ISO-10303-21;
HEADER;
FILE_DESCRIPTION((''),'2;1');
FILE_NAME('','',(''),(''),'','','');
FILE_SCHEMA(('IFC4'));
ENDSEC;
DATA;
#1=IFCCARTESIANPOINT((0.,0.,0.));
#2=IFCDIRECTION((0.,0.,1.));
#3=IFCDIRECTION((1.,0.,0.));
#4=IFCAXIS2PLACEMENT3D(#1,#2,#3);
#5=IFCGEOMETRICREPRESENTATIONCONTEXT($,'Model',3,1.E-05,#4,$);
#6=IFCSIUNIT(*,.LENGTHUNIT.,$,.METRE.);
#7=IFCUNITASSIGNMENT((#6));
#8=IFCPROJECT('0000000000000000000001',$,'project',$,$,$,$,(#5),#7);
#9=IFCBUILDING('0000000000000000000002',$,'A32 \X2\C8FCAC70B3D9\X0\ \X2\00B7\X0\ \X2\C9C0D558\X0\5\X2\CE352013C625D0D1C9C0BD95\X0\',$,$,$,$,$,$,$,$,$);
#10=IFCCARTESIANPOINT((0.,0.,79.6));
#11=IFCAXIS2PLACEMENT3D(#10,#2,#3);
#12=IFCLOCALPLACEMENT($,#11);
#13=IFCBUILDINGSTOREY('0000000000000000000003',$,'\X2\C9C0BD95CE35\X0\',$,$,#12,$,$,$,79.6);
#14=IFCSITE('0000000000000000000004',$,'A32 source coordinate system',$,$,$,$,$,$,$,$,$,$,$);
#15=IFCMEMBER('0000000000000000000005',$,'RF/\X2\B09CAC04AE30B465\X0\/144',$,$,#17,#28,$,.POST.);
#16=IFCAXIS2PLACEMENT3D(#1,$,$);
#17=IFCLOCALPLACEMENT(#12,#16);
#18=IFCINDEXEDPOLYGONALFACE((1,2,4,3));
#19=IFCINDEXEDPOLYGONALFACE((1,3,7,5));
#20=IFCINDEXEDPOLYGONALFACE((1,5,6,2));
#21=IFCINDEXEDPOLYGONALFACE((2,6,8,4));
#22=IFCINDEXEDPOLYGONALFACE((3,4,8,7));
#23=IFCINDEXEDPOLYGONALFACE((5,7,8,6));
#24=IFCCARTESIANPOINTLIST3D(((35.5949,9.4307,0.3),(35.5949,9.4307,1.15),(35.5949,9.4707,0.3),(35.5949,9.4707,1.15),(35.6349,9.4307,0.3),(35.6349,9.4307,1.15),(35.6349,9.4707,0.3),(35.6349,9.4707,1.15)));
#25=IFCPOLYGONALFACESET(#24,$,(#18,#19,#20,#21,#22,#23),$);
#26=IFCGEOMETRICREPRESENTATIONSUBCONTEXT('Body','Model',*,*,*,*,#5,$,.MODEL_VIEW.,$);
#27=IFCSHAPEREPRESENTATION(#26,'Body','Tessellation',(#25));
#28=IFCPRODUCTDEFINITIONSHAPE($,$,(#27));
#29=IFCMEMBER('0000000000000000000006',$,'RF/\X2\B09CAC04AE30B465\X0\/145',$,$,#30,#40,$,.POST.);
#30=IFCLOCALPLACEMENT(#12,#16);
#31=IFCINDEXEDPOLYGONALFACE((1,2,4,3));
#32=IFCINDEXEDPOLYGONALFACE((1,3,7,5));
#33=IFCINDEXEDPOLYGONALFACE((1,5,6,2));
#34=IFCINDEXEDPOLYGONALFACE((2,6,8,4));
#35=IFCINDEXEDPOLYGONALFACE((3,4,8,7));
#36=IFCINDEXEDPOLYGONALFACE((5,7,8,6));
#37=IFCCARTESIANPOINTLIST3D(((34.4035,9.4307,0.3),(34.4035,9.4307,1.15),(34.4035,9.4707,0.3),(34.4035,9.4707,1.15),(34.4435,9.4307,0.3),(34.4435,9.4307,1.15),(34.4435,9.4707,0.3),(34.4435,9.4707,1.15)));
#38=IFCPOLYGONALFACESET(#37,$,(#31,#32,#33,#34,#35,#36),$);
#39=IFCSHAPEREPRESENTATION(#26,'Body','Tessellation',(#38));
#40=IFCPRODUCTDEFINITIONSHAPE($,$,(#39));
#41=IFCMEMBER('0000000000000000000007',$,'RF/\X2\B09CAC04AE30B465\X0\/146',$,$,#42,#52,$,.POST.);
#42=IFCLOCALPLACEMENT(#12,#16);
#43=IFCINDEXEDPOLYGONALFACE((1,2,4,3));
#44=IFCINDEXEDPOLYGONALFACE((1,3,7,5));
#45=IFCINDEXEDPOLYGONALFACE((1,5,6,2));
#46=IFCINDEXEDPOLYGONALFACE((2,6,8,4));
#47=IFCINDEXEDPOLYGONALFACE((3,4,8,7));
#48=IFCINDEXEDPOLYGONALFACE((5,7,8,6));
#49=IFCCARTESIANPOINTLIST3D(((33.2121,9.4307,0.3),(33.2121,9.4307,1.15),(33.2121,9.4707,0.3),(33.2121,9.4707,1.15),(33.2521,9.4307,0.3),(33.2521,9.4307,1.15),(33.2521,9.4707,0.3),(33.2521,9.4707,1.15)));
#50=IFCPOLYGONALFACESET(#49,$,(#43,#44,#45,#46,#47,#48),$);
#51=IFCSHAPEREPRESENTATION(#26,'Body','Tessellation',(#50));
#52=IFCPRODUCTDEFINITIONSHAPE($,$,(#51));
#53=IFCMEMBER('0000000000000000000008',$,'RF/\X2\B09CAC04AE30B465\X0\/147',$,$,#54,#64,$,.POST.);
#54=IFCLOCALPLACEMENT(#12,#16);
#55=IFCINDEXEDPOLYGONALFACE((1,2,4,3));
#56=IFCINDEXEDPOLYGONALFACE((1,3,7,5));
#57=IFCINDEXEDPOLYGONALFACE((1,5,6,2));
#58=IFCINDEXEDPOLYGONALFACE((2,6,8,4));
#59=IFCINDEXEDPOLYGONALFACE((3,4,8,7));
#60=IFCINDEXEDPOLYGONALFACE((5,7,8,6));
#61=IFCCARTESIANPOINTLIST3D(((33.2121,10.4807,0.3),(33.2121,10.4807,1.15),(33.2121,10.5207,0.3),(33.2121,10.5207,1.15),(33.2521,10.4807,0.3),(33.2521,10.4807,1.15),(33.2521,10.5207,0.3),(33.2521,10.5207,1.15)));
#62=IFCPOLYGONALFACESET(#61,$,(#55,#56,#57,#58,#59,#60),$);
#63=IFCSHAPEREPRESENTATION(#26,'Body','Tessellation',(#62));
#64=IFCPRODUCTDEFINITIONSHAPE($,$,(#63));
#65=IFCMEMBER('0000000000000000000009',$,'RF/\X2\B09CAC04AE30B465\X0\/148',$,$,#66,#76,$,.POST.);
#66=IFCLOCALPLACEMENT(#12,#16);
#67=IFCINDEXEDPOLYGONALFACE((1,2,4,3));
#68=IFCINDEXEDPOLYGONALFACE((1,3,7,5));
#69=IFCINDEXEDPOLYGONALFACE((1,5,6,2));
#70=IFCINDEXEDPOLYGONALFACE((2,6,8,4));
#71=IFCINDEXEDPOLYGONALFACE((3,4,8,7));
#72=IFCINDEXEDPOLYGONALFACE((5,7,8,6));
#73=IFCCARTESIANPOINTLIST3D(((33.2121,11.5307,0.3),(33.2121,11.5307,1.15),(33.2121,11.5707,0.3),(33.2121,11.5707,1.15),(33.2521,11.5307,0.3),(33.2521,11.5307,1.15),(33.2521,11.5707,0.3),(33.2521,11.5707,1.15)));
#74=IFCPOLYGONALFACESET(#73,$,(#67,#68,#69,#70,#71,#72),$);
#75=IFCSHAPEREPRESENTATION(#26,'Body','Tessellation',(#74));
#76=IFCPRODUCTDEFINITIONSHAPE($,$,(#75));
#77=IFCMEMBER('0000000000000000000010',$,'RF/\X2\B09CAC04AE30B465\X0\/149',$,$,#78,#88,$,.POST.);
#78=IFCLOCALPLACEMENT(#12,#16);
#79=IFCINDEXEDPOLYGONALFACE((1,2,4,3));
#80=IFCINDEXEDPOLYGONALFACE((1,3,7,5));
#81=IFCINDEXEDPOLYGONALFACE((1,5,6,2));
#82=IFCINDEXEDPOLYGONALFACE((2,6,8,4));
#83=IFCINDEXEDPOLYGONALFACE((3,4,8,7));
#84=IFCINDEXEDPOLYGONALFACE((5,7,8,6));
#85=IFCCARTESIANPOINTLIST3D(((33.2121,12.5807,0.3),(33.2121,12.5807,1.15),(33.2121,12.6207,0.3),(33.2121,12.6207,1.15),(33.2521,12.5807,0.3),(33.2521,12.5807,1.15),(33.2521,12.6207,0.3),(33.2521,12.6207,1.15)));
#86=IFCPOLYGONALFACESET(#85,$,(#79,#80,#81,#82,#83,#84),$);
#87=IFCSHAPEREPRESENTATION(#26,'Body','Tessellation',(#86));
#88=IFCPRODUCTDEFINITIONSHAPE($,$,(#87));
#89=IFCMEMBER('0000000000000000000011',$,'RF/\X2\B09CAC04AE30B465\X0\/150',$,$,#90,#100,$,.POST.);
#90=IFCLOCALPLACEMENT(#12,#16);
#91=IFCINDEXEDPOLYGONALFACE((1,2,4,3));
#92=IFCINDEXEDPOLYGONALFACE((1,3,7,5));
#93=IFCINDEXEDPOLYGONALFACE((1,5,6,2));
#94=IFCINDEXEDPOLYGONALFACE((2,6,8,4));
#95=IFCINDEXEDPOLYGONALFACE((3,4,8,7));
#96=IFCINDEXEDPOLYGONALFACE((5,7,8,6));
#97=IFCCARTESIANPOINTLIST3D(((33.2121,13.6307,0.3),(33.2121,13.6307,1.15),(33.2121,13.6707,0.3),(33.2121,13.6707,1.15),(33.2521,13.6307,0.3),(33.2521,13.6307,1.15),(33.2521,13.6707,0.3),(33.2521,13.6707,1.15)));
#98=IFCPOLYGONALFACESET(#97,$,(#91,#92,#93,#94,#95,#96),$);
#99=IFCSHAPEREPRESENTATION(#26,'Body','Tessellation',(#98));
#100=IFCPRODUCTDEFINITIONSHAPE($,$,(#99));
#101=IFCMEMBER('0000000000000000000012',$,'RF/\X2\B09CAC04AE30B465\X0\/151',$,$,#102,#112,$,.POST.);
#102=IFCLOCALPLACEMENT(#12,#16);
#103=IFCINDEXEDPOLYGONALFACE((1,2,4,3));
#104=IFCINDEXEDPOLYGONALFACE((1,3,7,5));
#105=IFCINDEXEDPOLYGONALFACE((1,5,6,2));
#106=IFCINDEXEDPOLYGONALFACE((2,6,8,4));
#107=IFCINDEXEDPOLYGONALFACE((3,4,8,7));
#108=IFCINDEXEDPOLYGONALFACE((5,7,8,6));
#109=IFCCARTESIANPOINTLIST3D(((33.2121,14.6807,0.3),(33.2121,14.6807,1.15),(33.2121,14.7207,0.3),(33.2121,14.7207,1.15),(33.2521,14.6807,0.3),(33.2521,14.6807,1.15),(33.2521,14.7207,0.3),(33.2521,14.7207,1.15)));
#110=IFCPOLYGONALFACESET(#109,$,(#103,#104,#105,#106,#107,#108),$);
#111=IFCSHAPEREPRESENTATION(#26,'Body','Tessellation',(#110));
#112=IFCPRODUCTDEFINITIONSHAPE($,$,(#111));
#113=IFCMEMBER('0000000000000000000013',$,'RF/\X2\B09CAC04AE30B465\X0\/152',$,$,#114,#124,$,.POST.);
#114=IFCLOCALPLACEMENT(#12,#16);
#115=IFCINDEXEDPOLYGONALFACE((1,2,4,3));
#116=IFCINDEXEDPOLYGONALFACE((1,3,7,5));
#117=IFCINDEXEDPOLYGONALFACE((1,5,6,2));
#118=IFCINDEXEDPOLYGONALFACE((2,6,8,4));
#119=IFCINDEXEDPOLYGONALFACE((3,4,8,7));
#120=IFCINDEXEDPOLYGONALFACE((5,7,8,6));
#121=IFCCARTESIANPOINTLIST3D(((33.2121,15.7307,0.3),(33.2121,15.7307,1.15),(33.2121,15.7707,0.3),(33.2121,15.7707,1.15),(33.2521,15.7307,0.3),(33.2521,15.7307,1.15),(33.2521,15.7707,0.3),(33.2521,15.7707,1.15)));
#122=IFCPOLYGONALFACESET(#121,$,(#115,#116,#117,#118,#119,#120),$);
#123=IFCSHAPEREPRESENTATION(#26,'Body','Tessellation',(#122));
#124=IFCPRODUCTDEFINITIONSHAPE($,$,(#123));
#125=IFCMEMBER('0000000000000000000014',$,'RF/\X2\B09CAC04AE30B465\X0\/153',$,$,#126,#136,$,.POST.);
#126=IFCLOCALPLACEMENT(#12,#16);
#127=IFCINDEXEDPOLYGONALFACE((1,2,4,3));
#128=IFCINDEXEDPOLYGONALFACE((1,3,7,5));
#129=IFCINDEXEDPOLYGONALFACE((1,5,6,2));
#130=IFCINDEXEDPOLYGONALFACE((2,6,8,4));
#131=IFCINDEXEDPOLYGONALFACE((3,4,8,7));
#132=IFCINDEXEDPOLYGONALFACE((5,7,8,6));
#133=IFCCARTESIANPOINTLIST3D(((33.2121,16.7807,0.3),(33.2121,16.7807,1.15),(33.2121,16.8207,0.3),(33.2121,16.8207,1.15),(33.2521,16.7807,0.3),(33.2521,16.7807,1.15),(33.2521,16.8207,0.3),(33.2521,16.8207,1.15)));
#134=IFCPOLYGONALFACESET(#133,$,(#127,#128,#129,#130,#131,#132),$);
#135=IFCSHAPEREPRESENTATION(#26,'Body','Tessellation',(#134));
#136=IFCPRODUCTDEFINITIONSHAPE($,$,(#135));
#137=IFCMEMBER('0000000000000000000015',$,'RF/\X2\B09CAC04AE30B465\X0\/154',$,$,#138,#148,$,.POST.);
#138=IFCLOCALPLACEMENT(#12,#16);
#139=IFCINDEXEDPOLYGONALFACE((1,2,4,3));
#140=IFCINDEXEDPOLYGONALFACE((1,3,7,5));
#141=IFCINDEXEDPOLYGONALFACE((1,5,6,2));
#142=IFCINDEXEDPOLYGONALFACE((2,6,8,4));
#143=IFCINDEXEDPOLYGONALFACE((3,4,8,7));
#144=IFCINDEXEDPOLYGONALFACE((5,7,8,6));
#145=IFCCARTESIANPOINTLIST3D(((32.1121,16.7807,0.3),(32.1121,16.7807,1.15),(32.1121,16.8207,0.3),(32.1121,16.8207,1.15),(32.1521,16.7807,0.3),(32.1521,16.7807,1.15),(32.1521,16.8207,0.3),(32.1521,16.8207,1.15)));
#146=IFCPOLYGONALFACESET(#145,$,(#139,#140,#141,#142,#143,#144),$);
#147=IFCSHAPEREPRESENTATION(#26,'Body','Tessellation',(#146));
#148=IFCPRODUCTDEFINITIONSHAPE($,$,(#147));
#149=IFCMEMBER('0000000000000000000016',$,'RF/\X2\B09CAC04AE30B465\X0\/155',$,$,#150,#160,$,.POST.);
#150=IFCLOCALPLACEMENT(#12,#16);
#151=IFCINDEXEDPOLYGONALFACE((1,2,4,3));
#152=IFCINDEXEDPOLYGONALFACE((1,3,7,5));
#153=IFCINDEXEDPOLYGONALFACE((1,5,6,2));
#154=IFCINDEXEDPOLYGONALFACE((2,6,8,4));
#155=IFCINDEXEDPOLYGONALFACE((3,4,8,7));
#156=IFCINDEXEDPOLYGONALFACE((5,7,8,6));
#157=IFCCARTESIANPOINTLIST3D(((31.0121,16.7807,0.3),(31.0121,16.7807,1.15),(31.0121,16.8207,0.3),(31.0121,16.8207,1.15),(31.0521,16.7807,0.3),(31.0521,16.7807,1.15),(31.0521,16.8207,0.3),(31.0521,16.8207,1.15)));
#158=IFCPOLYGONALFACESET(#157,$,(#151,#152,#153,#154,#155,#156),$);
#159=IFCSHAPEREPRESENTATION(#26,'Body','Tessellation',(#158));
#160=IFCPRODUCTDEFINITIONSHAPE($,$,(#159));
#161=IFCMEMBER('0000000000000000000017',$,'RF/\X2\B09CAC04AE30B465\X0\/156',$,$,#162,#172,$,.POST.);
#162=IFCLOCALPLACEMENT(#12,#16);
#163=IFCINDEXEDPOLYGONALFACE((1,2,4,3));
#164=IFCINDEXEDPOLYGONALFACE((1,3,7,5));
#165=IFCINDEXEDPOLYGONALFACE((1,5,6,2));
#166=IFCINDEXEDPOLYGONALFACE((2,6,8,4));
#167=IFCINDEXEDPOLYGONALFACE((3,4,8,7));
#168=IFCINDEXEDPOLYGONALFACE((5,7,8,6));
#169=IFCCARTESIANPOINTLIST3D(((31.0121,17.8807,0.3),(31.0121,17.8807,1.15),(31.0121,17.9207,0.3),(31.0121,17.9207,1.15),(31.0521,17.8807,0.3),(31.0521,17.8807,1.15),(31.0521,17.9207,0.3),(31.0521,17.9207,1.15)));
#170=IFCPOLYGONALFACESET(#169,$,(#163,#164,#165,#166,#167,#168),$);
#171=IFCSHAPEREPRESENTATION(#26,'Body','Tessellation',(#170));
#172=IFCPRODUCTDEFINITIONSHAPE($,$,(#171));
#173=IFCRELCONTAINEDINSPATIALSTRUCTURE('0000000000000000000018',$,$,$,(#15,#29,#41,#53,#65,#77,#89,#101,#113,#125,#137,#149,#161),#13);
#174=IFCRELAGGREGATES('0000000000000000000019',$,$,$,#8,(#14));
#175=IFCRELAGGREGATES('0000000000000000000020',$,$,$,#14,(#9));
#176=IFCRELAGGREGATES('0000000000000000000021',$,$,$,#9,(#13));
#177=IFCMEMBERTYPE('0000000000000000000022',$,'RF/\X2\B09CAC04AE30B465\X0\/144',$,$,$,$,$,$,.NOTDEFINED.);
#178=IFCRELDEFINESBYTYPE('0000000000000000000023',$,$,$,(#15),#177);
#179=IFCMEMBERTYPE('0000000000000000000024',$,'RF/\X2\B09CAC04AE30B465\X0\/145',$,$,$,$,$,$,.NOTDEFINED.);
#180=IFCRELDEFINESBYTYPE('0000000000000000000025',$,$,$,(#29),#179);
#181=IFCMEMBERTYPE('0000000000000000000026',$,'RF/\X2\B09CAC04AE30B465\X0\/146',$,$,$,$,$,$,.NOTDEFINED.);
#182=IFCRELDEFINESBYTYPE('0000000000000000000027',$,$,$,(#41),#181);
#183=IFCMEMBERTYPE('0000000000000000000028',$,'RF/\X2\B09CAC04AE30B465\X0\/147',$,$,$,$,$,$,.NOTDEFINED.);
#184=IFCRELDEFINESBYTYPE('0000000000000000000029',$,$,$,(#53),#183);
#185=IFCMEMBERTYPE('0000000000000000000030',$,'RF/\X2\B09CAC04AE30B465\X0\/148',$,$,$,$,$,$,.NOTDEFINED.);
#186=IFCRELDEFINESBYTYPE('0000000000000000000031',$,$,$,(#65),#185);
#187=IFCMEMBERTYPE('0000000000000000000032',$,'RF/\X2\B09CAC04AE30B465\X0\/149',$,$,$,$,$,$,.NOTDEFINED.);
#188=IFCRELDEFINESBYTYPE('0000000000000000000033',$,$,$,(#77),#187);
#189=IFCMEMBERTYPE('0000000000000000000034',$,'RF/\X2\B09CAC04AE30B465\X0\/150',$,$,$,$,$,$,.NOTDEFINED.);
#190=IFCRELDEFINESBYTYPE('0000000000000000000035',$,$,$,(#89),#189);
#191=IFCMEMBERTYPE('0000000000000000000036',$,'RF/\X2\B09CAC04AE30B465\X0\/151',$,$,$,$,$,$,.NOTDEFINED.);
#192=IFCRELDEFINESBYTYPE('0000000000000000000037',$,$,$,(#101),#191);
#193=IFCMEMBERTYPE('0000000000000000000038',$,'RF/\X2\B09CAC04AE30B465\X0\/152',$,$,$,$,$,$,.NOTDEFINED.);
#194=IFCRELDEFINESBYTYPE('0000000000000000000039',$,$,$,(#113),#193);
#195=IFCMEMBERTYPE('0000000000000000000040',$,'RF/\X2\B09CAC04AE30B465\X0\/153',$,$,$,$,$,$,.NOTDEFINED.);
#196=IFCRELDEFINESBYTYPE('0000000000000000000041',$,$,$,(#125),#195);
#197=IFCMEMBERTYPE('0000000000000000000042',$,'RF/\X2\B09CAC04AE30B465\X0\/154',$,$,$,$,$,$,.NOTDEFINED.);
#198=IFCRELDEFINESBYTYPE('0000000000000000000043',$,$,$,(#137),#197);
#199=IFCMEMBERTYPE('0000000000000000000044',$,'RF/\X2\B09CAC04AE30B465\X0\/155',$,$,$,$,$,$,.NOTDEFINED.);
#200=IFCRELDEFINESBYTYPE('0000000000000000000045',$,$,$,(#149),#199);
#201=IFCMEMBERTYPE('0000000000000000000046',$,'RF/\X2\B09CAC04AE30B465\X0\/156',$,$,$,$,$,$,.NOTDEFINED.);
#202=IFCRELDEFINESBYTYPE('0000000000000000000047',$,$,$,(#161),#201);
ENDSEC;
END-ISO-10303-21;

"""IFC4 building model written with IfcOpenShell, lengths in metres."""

from ifc_helpers import new_model, si_unit, frame, origin, origin_with_axes, place, context, subcontext, project, spatial, polyline, outline, extrude, source, transform, mapped, type_object, type_shapes, element, save


model = new_model("IFC4")

# Units and contexts
model_context = context("Model", 3, precision=1e-05, world=origin_with_axes())
body_context = subcontext(model_context, "Body", "Model", "MODEL_VIEW")
ifc_project = project(units=[si_unit("LENGTHUNIT", "METRE")], contexts=[model_context])

# Site, building, storey
site = spatial("IfcSite", under=ifc_project, Name="A32 source coordinate system")
building = spatial("IfcBuilding", under=site, Name="A32 주거동 · 지하5층–옥탑지붕")
storey_placement = place(None, frame((0.0, 0.0, 79.6), z_axis=(0.0, 0.0, 1.0), x_axis=(1.0, 0.0, 0.0)))
storey = spatial("IfcBuildingStorey", under=building, at=storey_placement, Name="지붕층", Elevation=79.6)

# Members
member_type_1 = type_object("IfcMemberType", Name="RF/난간기둥/144", PredefinedType="NOTDEFINED")
shared_shape_1 = source(origin(), body_context, "Body", "SweptSolid", [
    extrude(outline(polyline([(35.6349, 9.4307), (35.5949, 9.4307), (35.5949, 9.4707), (35.6349, 9.4707), (35.6349, 9.4307)])), frame((0.0, 0.0, 0.3)), (0.0, 0.0, 1.0), 0.85),
])
type_shapes(member_type_1, [shared_shape_1])
member_1_placement = place(storey_placement, origin_with_axes())
element("IfcMember", 1, at=member_1_placement, inside=storey, type_object=member_type_1, Name="RF/난간기둥/144", PredefinedType="POST", context=body_context, shape_type="MappedRepresentation", body=[
    mapped(shared_shape_1, transform((0.0, 0.0, 0.0), scale=1.0)),
])
member_type_2 = type_object("IfcMemberType", Name="RF/난간기둥/145", PredefinedType="NOTDEFINED")
shared_shape_2 = source(origin(), body_context, "Body", "SweptSolid", [
    extrude(outline(polyline([(34.4435, 9.4307), (34.4035, 9.4307), (34.4035, 9.4707), (34.4435, 9.4707), (34.4435, 9.4307)])), frame((0.0, 0.0, 0.3)), (0.0, 0.0, 1.0), 0.85),
])
type_shapes(member_type_2, [shared_shape_2])
member_2_placement = place(storey_placement, origin_with_axes())
element("IfcMember", 2, at=member_2_placement, inside=storey, type_object=member_type_2, Name="RF/난간기둥/145", PredefinedType="POST", context=body_context, shape_type="MappedRepresentation", body=[
    mapped(shared_shape_2, transform((0.0, 0.0, 0.0), scale=1.0)),
])
member_type_3 = type_object("IfcMemberType", Name="RF/난간기둥/146", PredefinedType="NOTDEFINED")
shared_shape_3 = source(origin(), body_context, "Body", "SweptSolid", [
    extrude(outline(polyline([(33.2521, 9.4307), (33.2121, 9.4307), (33.2121, 9.4707), (33.2521, 9.4707), (33.2521, 9.4307)])), frame((0.0, 0.0, 0.3)), (0.0, 0.0, 1.0), 0.85),
])
type_shapes(member_type_3, [shared_shape_3])
member_3_placement = place(storey_placement, origin_with_axes())
element("IfcMember", 3, at=member_3_placement, inside=storey, type_object=member_type_3, Name="RF/난간기둥/146", PredefinedType="POST", context=body_context, shape_type="MappedRepresentation", body=[
    mapped(shared_shape_3, transform((0.0, 0.0, 0.0), scale=1.0)),
])
member_type_4 = type_object("IfcMemberType", Name="RF/난간기둥/147", PredefinedType="NOTDEFINED")
shared_shape_4 = source(origin(), body_context, "Body", "SweptSolid", [
    extrude(outline(polyline([(33.2521, 10.4807), (33.2121, 10.4807), (33.2121, 10.5207), (33.2521, 10.5207), (33.2521, 10.4807)])), frame((0.0, 0.0, 0.3)), (0.0, 0.0, 1.0), 0.85),
])
type_shapes(member_type_4, [shared_shape_4])
member_4_placement = place(storey_placement, origin_with_axes())
element("IfcMember", 4, at=member_4_placement, inside=storey, type_object=member_type_4, Name="RF/난간기둥/147", PredefinedType="POST", context=body_context, shape_type="MappedRepresentation", body=[
    mapped(shared_shape_4, transform((0.0, 0.0, 0.0), scale=1.0)),
])
member_type_5 = type_object("IfcMemberType", Name="RF/난간기둥/148", PredefinedType="NOTDEFINED")
shared_shape_5 = source(origin(), body_context, "Body", "SweptSolid", [
    extrude(outline(polyline([(33.2521, 11.5307), (33.2121, 11.5307), (33.2121, 11.5707), (33.2521, 11.5707), (33.2521, 11.5307)])), frame((0.0, 0.0, 0.3)), (0.0, 0.0, 1.0), 0.85),
])
type_shapes(member_type_5, [shared_shape_5])
member_5_placement = place(storey_placement, origin_with_axes())
element("IfcMember", 5, at=member_5_placement, inside=storey, type_object=member_type_5, Name="RF/난간기둥/148", PredefinedType="POST", context=body_context, shape_type="MappedRepresentation", body=[
    mapped(shared_shape_5, transform((0.0, 0.0, 0.0), scale=1.0)),
])
member_type_6 = type_object("IfcMemberType", Name="RF/난간기둥/149", PredefinedType="NOTDEFINED")
shared_shape_6 = source(origin(), body_context, "Body", "SweptSolid", [
    extrude(outline(polyline([(33.2521, 12.5807), (33.2121, 12.5807), (33.2121, 12.6207), (33.2521, 12.6207), (33.2521, 12.5807)])), frame((0.0, 0.0, 0.3)), (0.0, 0.0, 1.0), 0.85),
])
type_shapes(member_type_6, [shared_shape_6])
member_6_placement = place(storey_placement, origin_with_axes())
element("IfcMember", 6, at=member_6_placement, inside=storey, type_object=member_type_6, Name="RF/난간기둥/149", PredefinedType="POST", context=body_context, shape_type="MappedRepresentation", body=[
    mapped(shared_shape_6, transform((0.0, 0.0, 0.0), scale=1.0)),
])
member_type_7 = type_object("IfcMemberType", Name="RF/난간기둥/150", PredefinedType="NOTDEFINED")
shared_shape_7 = source(origin(), body_context, "Body", "SweptSolid", [
    extrude(outline(polyline([(33.2521, 13.6307), (33.2121, 13.6307), (33.2121, 13.6707), (33.2521, 13.6707), (33.2521, 13.6307)])), frame((0.0, 0.0, 0.3)), (0.0, 0.0, 1.0), 0.85),
])
type_shapes(member_type_7, [shared_shape_7])
member_7_placement = place(storey_placement, origin_with_axes())
element("IfcMember", 7, at=member_7_placement, inside=storey, type_object=member_type_7, Name="RF/난간기둥/150", PredefinedType="POST", context=body_context, shape_type="MappedRepresentation", body=[
    mapped(shared_shape_7, transform((0.0, 0.0, 0.0), scale=1.0)),
])
member_type_8 = type_object("IfcMemberType", Name="RF/난간기둥/151", PredefinedType="NOTDEFINED")
shared_shape_8 = source(origin(), body_context, "Body", "SweptSolid", [
    extrude(outline(polyline([(33.2521, 14.6807), (33.2121, 14.6807), (33.2121, 14.7207), (33.2521, 14.7207), (33.2521, 14.6807)])), frame((0.0, 0.0, 0.3)), (0.0, 0.0, 1.0), 0.85),
])
type_shapes(member_type_8, [shared_shape_8])
member_8_placement = place(storey_placement, origin_with_axes())
element("IfcMember", 8, at=member_8_placement, inside=storey, type_object=member_type_8, Name="RF/난간기둥/151", PredefinedType="POST", context=body_context, shape_type="MappedRepresentation", body=[
    mapped(shared_shape_8, transform((0.0, 0.0, 0.0), scale=1.0)),
])
member_type_9 = type_object("IfcMemberType", Name="RF/난간기둥/152", PredefinedType="NOTDEFINED")
shared_shape_9 = source(origin(), body_context, "Body", "SweptSolid", [
    extrude(outline(polyline([(33.2521, 15.7307), (33.2121, 15.7307), (33.2121, 15.7707), (33.2521, 15.7707), (33.2521, 15.7307)])), frame((0.0, 0.0, 0.3)), (0.0, 0.0, 1.0), 0.85),
])
type_shapes(member_type_9, [shared_shape_9])
member_9_placement = place(storey_placement, origin_with_axes())
element("IfcMember", 9, at=member_9_placement, inside=storey, type_object=member_type_9, Name="RF/난간기둥/152", PredefinedType="POST", context=body_context, shape_type="MappedRepresentation", body=[
    mapped(shared_shape_9, transform((0.0, 0.0, 0.0), scale=1.0)),
])
member_type_10 = type_object("IfcMemberType", Name="RF/난간기둥/153", PredefinedType="NOTDEFINED")
shared_shape_10 = source(origin(), body_context, "Body", "SweptSolid", [
    extrude(outline(polyline([(33.2521, 16.7807), (33.2121, 16.7807), (33.2121, 16.8207), (33.2521, 16.8207), (33.2521, 16.7807)])), frame((0.0, 0.0, 0.3)), (0.0, 0.0, 1.0), 0.85),
])
type_shapes(member_type_10, [shared_shape_10])
member_10_placement = place(storey_placement, origin_with_axes())
element("IfcMember", 10, at=member_10_placement, inside=storey, type_object=member_type_10, Name="RF/난간기둥/153", PredefinedType="POST", context=body_context, shape_type="MappedRepresentation", body=[
    mapped(shared_shape_10, transform((0.0, 0.0, 0.0), scale=1.0)),
])
member_type_11 = type_object("IfcMemberType", Name="RF/난간기둥/154", PredefinedType="NOTDEFINED")
shared_shape_11 = source(origin(), body_context, "Body", "SweptSolid", [
    extrude(outline(polyline([(32.1521, 16.7807), (32.1121, 16.7807), (32.1121, 16.8207), (32.1521, 16.8207), (32.1521, 16.7807)])), frame((0.0, 0.0, 0.3)), (0.0, 0.0, 1.0), 0.85),
])
type_shapes(member_type_11, [shared_shape_11])
member_11_placement = place(storey_placement, origin_with_axes())
element("IfcMember", 11, at=member_11_placement, inside=storey, type_object=member_type_11, Name="RF/난간기둥/154", PredefinedType="POST", context=body_context, shape_type="MappedRepresentation", body=[
    mapped(shared_shape_11, transform((0.0, 0.0, 0.0), scale=1.0)),
])
member_type_12 = type_object("IfcMemberType", Name="RF/난간기둥/155", PredefinedType="NOTDEFINED")
shared_shape_12 = source(origin(), body_context, "Body", "SweptSolid", [
    extrude(outline(polyline([(31.0521, 16.7807), (31.0121, 16.7807), (31.0121, 16.8207), (31.0521, 16.8207), (31.0521, 16.7807)])), frame((0.0, 0.0, 0.3)), (0.0, 0.0, 1.0), 0.85),
])
type_shapes(member_type_12, [shared_shape_12])
member_12_placement = place(storey_placement, origin_with_axes())
element("IfcMember", 12, at=member_12_placement, inside=storey, type_object=member_type_12, Name="RF/난간기둥/155", PredefinedType="POST", context=body_context, shape_type="MappedRepresentation", body=[
    mapped(shared_shape_12, transform((0.0, 0.0, 0.0), scale=1.0)),
])
member_type_13 = type_object("IfcMemberType", Name="RF/난간기둥/156", PredefinedType="NOTDEFINED")
shared_shape_13 = source(origin(), body_context, "Body", "SweptSolid", [
    extrude(outline(polyline([(31.0521, 17.8807), (31.0121, 17.8807), (31.0121, 17.9207), (31.0521, 17.9207), (31.0521, 17.8807)])), frame((0.0, 0.0, 0.3)), (0.0, 0.0, 1.0), 0.85),
])
type_shapes(member_type_13, [shared_shape_13])
member_13_placement = place(storey_placement, origin_with_axes())
element("IfcMember", 13, at=member_13_placement, inside=storey, type_object=member_type_13, Name="RF/난간기둥/156", PredefinedType="POST", context=body_context, shape_type="MappedRepresentation", body=[
    mapped(shared_shape_13, transform((0.0, 0.0, 0.0), scale=1.0)),
])

save(model, "model.ifc")
